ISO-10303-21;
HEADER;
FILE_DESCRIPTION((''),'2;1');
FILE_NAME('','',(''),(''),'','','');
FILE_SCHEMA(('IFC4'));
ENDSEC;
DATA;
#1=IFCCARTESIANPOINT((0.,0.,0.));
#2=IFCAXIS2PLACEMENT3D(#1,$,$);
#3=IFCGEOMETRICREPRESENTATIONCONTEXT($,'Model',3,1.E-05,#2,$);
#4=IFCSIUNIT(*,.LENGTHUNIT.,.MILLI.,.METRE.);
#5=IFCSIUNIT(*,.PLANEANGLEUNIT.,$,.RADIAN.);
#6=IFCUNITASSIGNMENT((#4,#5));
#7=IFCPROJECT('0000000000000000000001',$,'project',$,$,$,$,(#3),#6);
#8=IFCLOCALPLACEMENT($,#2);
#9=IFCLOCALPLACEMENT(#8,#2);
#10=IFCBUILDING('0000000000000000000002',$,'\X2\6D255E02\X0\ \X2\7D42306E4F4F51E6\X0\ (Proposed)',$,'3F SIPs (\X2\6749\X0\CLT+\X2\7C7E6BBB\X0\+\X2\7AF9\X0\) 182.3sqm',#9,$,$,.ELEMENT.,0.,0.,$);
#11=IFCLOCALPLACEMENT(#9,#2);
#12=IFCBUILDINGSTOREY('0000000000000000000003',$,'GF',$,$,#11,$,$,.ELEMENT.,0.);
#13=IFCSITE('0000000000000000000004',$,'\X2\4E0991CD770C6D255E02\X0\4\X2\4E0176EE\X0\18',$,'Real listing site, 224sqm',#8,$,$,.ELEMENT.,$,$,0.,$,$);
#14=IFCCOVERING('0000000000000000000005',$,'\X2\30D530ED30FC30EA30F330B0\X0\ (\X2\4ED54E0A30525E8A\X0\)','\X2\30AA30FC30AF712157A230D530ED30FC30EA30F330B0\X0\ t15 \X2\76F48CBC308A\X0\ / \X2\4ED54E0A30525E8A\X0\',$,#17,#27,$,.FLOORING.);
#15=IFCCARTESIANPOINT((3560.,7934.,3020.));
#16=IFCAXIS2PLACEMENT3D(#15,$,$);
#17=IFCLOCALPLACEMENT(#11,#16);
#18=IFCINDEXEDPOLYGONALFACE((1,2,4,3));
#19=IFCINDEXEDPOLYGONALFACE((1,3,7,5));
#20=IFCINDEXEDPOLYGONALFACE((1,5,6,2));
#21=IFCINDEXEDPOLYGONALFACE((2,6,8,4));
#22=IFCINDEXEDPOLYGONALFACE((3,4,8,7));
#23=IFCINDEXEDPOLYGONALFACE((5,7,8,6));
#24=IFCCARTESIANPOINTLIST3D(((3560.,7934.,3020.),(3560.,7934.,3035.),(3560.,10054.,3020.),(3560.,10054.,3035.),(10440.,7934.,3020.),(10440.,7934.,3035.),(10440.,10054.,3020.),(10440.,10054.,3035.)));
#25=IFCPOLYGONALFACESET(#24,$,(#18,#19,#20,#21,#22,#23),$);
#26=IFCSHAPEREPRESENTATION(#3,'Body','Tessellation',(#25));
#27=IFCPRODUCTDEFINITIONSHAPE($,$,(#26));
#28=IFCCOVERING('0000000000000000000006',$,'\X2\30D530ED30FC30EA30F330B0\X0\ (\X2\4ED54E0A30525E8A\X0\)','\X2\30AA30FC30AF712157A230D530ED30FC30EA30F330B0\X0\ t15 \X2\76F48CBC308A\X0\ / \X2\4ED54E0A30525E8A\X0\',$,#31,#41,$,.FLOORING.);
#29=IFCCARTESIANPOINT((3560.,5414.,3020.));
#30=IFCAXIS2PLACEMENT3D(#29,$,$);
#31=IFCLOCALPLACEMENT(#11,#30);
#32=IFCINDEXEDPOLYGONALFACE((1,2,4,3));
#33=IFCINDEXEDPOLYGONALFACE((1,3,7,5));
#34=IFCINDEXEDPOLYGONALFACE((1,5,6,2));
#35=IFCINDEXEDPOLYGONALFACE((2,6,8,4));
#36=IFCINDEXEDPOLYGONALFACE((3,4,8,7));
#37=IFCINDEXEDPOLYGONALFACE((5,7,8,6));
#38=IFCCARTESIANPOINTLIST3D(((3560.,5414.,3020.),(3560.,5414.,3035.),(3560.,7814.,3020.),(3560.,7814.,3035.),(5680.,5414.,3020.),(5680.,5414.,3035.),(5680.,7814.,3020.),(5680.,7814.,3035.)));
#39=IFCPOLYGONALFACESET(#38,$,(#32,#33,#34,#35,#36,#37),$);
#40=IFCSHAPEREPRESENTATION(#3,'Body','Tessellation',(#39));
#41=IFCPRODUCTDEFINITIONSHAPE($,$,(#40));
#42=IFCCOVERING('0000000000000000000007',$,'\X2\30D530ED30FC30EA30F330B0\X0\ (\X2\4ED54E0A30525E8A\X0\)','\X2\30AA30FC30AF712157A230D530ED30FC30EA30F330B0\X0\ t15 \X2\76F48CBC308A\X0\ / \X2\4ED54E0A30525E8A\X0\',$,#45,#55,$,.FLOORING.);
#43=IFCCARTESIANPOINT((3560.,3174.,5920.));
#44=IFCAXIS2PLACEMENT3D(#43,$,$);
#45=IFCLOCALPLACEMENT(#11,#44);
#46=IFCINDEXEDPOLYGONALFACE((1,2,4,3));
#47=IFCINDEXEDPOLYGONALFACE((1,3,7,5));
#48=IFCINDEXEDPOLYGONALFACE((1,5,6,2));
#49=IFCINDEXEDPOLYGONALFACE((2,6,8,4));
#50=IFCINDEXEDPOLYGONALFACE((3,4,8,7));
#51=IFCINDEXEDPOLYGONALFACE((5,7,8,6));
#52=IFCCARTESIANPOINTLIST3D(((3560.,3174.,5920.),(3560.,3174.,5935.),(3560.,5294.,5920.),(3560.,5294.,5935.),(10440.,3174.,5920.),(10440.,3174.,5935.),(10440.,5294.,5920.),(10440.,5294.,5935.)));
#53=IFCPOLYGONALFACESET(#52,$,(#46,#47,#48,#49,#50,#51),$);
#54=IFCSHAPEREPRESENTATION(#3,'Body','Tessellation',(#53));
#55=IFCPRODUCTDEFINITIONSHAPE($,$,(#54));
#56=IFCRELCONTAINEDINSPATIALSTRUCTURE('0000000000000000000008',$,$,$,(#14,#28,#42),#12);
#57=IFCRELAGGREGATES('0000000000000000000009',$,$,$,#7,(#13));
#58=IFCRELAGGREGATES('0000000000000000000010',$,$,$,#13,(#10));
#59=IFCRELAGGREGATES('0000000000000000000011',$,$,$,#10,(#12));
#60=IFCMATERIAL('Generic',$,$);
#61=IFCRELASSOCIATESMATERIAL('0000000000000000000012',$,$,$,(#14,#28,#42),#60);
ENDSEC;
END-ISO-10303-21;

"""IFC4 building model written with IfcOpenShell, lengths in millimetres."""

from ifc_helpers import new_model, si_unit, frame, frame_2d, origin, place, context, project, spatial, rectangle, extrude, material, element, save


model = new_model("IFC4")

# Units and contexts
model_context = context("Model", 3, precision=1e-05, world=origin())
ifc_project = project(units=[si_unit("LENGTHUNIT", "METRE", prefix="MILLI"), si_unit("PLANEANGLEUNIT", "RADIAN")], contexts=[model_context])

# Site, building, storey
site_placement = place(None, origin())
site = spatial("IfcSite", under=ifc_project, at=site_placement, Name="三重県津市4丁目18", ObjectType="Real listing site, 224sqm", CompositionType="ELEMENT", RefElevation=0.0)
building_placement = place(site_placement, origin())
building = spatial("IfcBuilding", under=site, at=building_placement, Name="津市 終の住処 (Proposed)", ObjectType="3F SIPs (杉CLT+籾殻+竹) 182.3sqm", CompositionType="ELEMENT", ElevationOfRefHeight=0.0, ElevationOfTerrain=0.0)
storey_placement = place(building_placement, origin())
storey = spatial("IfcBuildingStorey", under=building, at=storey_placement, Name="GF", CompositionType="ELEMENT", Elevation=0.0)

# Shared definitions
ifc_material_1 = material(Name="Generic")

# Coverings
covering_1_placement = place(storey_placement, frame((3560.0, 7934.0, 3020.0)))
element("IfcCovering", 1, at=covering_1_placement, inside=storey, material=ifc_material_1, Name="フローリング (仕上げ床)", Description="オーク無垢フローリング t15 直貼り / 仕上げ床", PredefinedType="FLOORING", context=model_context, shape_type="SweptSolid", body=[
    extrude(rectangle(XDim=6880.0, YDim=2120.0, at=frame_2d((3440.0, 1060.0))), frame((3560.0, 7934.0, 3020.0)), (0.0, 0.0, 1.0), 15.0),
])
covering_2_placement = place(storey_placement, frame((3560.0, 5414.0, 3020.0)))
element("IfcCovering", 2, at=covering_2_placement, inside=storey, material=ifc_material_1, Name="フローリング (仕上げ床)", Description="オーク無垢フローリング t15 直貼り / 仕上げ床", PredefinedType="FLOORING", context=model_context, shape_type="SweptSolid", body=[
    extrude(rectangle(XDim=2120.0, YDim=2400.0, at=frame_2d((1060.0, 1200.0))), frame((3560.0, 5414.0, 3020.0)), (0.0, 0.0, 1.0), 15.0),
])
covering_3_placement = place(storey_placement, frame((3560.0, 3174.0, 5920.0)))
element("IfcCovering", 3, at=covering_3_placement, inside=storey, material=ifc_material_1, Name="フローリング (仕上げ床)", Description="オーク無垢フローリング t15 直貼り / 仕上げ床", PredefinedType="FLOORING", context=model_context, shape_type="SweptSolid", body=[
    extrude(rectangle(XDim=6880.0, YDim=2120.0, at=frame_2d((3440.0, 1060.0))), frame((3560.0, 3174.0, 5920.0)), (0.0, 0.0, 1.0), 15.0),
])

save(model, "model.ifc")
